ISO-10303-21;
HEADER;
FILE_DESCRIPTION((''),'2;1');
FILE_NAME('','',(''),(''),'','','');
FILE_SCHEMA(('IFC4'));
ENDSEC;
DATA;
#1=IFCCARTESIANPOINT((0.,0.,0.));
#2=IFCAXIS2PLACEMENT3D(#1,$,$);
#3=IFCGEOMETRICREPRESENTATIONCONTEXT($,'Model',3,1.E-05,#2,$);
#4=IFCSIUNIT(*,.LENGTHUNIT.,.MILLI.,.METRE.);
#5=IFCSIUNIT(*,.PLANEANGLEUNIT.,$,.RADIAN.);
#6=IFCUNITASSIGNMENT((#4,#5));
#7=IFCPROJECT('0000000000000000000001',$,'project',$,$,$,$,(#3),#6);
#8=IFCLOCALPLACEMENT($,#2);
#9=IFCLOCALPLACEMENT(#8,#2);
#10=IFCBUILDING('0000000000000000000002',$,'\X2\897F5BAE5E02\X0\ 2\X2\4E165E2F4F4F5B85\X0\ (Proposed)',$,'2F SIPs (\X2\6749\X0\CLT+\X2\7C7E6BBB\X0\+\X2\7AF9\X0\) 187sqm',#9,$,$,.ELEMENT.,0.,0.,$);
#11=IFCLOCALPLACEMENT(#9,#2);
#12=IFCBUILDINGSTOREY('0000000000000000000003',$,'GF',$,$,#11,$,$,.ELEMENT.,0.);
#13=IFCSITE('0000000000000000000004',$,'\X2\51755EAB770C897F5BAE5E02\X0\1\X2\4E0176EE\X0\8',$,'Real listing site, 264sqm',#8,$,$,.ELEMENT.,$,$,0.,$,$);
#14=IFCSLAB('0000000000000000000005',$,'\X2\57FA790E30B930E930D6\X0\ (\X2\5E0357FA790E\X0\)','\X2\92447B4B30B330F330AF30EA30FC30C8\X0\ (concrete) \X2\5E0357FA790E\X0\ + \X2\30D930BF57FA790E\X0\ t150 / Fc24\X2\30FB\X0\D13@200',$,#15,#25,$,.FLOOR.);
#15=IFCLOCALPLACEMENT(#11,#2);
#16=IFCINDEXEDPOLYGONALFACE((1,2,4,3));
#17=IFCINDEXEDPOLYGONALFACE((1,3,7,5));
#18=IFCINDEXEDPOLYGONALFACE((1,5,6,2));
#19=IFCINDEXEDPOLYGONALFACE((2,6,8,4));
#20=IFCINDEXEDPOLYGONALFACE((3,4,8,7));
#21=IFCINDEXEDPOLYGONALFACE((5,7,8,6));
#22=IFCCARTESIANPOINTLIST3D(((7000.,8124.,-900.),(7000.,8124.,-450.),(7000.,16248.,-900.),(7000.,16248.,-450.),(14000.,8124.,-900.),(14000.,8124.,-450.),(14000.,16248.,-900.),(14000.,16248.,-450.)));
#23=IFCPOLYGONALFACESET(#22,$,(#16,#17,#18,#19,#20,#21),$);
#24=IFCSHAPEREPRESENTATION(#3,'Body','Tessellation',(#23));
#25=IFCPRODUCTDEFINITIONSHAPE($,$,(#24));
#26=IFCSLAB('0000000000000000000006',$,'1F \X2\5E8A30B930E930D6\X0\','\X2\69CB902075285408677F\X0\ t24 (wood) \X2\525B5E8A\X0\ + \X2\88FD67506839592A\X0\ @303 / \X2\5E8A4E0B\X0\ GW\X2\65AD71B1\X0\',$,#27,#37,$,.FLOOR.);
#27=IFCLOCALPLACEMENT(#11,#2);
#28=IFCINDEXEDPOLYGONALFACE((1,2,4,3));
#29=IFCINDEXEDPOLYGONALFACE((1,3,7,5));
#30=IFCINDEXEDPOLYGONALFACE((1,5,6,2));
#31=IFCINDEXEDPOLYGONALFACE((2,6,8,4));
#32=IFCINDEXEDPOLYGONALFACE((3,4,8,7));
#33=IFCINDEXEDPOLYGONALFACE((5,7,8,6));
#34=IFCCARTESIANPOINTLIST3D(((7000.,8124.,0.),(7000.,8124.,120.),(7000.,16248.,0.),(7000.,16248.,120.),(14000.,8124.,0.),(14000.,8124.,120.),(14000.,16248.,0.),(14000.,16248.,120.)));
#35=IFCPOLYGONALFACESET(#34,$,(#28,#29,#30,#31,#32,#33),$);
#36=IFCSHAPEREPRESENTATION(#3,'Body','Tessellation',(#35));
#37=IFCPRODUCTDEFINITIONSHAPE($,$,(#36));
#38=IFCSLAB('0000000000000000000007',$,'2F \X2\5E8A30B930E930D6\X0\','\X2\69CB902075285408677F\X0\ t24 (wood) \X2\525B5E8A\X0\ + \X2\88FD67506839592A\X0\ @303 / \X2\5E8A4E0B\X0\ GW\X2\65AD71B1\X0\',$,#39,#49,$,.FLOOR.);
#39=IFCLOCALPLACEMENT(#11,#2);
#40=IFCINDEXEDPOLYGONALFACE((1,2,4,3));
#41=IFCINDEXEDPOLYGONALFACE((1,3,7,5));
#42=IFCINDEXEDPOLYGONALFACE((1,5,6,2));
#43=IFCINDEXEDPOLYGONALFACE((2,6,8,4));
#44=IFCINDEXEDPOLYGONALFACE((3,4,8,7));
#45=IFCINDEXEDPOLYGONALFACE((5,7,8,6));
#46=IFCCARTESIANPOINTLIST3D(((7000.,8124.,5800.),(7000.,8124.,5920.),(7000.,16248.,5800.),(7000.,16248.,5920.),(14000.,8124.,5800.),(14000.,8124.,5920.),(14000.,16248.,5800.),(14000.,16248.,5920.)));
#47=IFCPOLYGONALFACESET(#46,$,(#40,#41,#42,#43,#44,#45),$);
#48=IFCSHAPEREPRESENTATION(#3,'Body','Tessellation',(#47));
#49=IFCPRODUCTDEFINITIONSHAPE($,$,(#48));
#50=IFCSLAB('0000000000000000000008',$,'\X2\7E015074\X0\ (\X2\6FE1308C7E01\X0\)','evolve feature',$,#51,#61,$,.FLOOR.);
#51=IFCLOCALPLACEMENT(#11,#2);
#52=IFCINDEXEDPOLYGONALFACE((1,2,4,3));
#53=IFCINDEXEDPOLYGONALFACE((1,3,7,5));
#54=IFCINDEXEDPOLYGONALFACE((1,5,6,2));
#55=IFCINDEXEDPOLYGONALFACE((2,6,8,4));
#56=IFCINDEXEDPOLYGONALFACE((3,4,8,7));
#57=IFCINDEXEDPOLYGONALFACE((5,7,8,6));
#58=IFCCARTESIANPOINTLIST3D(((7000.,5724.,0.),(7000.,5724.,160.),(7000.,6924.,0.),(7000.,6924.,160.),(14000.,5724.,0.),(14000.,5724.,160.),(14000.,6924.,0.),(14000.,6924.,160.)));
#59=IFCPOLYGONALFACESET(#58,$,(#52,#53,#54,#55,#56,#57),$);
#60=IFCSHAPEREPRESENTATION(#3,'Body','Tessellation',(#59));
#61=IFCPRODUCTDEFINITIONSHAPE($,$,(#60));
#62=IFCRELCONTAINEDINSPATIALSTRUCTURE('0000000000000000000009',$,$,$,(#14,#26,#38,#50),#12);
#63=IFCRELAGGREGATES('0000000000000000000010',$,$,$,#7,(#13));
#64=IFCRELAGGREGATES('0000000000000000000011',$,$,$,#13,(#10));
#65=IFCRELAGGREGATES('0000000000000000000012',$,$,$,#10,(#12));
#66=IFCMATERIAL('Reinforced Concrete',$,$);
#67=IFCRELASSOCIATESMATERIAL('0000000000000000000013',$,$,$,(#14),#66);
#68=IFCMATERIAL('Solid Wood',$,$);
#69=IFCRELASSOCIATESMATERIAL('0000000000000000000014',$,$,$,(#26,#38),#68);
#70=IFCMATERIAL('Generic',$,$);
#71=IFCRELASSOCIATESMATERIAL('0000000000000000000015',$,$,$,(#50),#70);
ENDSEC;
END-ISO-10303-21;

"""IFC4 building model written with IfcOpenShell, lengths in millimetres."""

from ifc_helpers import new_model, si_unit, frame, frame_2d, origin, place, context, project, spatial, rectangle, extrude, material, element, save


model = new_model("IFC4")

# Units and contexts
model_context = context("Model", 3, precision=1e-05, world=origin())
ifc_project = project(units=[si_unit("LENGTHUNIT", "METRE", prefix="MILLI"), si_unit("PLANEANGLEUNIT", "RADIAN")], contexts=[model_context])

# Site, building, storey
site_placement = place(None, origin())
site = spatial("IfcSite", under=ifc_project, at=site_placement, Name="兵庫県西宮市1丁目8", ObjectType="Real listing site, 264sqm", CompositionType="ELEMENT", RefElevation=0.0)
building_placement = place(site_placement, origin())
building = spatial("IfcBuilding", under=site, at=building_placement, Name="西宮市 2世帯住宅 (Proposed)", ObjectType="2F SIPs (杉CLT+籾殻+竹) 187sqm", CompositionType="ELEMENT", ElevationOfRefHeight=0.0, ElevationOfTerrain=0.0)
storey_placement = place(building_placement, origin())
storey = spatial("IfcBuildingStorey", under=building, at=storey_placement, Name="GF", CompositionType="ELEMENT", Elevation=0.0)

# Slabs
ifc_material_1 = material(Name="Reinforced Concrete")
slab_1_placement = place(storey_placement, frame((3500.0, 4062.0, -450.0)))
element("IfcSlab", 1, at=slab_1_placement, inside=storey, material=ifc_material_1, Name="基礎スラブ (布基礎)", Description="鉄筋コンクリート (concrete) 布基礎 + ベタ基礎 t150 / Fc24・D13@200", PredefinedType="FLOOR", context=model_context, shape_type="SweptSolid", body=[
    extrude(rectangle(XDim=7000.0, YDim=8124.0, at=frame_2d((3500.0, 4062.0))), frame((3500.0, 4062.0, -450.0)), (0.0, 0.0, 1.0), 450.0),
])
ifc_material_2 = material(Name="Solid Wood")
slab_2_placement = place(storey_placement, frame((3500.0, 4062.0, 0.0)))
element("IfcSlab", 2, at=slab_2_placement, inside=storey, material=ifc_material_2, Name="1F 床スラブ", Description="構造用合板 t24 (wood) 剛床 + 製材根太 @303 / 床下 GW断熱", PredefinedType="FLOOR", context=model_context, shape_type="SweptSolid", body=[
    extrude(rectangle(XDim=7000.0, YDim=8124.0, at=frame_2d((3500.0, 4062.0))), frame((3500.0, 4062.0, 0.0)), (0.0, 0.0, 1.0), 120.0),
])
slab_3_placement = place(storey_placement, frame((3500.0, 4062.0, 2900.0)))
element("IfcSlab", 3, at=slab_3_placement, inside=storey, material=ifc_material_2, Name="2F 床スラブ", Description="構造用合板 t24 (wood) 剛床 + 製材根太 @303 / 床下 GW断熱", PredefinedType="FLOOR", context=model_context, shape_type="SweptSolid", body=[
    extrude(rectangle(XDim=7000.0, YDim=8124.0, at=frame_2d((3500.0, 4062.0))), frame((3500.0, 4062.0, 2900.0)), (0.0, 0.0, 1.0), 120.0),
])
ifc_material_3 = material(Name="Generic")
slab_4_placement = place(storey_placement, frame((3500.0, 2862.0, 0.0)))
element("IfcSlab", 4, at=slab_4_placement, inside=storey, material=ifc_material_3, Name="縁側 (濡れ縁)", Description="evolve feature", PredefinedType="FLOOR", context=model_context, shape_type="SweptSolid", body=[
    extrude(rectangle(XDim=7000.0, YDim=1200.0, at=frame_2d((3500.0, 600.0))), frame((3500.0, 2862.0, 0.0)), (0.0, 0.0, 1.0), 160.0),
])

save(model, "model.ifc")
